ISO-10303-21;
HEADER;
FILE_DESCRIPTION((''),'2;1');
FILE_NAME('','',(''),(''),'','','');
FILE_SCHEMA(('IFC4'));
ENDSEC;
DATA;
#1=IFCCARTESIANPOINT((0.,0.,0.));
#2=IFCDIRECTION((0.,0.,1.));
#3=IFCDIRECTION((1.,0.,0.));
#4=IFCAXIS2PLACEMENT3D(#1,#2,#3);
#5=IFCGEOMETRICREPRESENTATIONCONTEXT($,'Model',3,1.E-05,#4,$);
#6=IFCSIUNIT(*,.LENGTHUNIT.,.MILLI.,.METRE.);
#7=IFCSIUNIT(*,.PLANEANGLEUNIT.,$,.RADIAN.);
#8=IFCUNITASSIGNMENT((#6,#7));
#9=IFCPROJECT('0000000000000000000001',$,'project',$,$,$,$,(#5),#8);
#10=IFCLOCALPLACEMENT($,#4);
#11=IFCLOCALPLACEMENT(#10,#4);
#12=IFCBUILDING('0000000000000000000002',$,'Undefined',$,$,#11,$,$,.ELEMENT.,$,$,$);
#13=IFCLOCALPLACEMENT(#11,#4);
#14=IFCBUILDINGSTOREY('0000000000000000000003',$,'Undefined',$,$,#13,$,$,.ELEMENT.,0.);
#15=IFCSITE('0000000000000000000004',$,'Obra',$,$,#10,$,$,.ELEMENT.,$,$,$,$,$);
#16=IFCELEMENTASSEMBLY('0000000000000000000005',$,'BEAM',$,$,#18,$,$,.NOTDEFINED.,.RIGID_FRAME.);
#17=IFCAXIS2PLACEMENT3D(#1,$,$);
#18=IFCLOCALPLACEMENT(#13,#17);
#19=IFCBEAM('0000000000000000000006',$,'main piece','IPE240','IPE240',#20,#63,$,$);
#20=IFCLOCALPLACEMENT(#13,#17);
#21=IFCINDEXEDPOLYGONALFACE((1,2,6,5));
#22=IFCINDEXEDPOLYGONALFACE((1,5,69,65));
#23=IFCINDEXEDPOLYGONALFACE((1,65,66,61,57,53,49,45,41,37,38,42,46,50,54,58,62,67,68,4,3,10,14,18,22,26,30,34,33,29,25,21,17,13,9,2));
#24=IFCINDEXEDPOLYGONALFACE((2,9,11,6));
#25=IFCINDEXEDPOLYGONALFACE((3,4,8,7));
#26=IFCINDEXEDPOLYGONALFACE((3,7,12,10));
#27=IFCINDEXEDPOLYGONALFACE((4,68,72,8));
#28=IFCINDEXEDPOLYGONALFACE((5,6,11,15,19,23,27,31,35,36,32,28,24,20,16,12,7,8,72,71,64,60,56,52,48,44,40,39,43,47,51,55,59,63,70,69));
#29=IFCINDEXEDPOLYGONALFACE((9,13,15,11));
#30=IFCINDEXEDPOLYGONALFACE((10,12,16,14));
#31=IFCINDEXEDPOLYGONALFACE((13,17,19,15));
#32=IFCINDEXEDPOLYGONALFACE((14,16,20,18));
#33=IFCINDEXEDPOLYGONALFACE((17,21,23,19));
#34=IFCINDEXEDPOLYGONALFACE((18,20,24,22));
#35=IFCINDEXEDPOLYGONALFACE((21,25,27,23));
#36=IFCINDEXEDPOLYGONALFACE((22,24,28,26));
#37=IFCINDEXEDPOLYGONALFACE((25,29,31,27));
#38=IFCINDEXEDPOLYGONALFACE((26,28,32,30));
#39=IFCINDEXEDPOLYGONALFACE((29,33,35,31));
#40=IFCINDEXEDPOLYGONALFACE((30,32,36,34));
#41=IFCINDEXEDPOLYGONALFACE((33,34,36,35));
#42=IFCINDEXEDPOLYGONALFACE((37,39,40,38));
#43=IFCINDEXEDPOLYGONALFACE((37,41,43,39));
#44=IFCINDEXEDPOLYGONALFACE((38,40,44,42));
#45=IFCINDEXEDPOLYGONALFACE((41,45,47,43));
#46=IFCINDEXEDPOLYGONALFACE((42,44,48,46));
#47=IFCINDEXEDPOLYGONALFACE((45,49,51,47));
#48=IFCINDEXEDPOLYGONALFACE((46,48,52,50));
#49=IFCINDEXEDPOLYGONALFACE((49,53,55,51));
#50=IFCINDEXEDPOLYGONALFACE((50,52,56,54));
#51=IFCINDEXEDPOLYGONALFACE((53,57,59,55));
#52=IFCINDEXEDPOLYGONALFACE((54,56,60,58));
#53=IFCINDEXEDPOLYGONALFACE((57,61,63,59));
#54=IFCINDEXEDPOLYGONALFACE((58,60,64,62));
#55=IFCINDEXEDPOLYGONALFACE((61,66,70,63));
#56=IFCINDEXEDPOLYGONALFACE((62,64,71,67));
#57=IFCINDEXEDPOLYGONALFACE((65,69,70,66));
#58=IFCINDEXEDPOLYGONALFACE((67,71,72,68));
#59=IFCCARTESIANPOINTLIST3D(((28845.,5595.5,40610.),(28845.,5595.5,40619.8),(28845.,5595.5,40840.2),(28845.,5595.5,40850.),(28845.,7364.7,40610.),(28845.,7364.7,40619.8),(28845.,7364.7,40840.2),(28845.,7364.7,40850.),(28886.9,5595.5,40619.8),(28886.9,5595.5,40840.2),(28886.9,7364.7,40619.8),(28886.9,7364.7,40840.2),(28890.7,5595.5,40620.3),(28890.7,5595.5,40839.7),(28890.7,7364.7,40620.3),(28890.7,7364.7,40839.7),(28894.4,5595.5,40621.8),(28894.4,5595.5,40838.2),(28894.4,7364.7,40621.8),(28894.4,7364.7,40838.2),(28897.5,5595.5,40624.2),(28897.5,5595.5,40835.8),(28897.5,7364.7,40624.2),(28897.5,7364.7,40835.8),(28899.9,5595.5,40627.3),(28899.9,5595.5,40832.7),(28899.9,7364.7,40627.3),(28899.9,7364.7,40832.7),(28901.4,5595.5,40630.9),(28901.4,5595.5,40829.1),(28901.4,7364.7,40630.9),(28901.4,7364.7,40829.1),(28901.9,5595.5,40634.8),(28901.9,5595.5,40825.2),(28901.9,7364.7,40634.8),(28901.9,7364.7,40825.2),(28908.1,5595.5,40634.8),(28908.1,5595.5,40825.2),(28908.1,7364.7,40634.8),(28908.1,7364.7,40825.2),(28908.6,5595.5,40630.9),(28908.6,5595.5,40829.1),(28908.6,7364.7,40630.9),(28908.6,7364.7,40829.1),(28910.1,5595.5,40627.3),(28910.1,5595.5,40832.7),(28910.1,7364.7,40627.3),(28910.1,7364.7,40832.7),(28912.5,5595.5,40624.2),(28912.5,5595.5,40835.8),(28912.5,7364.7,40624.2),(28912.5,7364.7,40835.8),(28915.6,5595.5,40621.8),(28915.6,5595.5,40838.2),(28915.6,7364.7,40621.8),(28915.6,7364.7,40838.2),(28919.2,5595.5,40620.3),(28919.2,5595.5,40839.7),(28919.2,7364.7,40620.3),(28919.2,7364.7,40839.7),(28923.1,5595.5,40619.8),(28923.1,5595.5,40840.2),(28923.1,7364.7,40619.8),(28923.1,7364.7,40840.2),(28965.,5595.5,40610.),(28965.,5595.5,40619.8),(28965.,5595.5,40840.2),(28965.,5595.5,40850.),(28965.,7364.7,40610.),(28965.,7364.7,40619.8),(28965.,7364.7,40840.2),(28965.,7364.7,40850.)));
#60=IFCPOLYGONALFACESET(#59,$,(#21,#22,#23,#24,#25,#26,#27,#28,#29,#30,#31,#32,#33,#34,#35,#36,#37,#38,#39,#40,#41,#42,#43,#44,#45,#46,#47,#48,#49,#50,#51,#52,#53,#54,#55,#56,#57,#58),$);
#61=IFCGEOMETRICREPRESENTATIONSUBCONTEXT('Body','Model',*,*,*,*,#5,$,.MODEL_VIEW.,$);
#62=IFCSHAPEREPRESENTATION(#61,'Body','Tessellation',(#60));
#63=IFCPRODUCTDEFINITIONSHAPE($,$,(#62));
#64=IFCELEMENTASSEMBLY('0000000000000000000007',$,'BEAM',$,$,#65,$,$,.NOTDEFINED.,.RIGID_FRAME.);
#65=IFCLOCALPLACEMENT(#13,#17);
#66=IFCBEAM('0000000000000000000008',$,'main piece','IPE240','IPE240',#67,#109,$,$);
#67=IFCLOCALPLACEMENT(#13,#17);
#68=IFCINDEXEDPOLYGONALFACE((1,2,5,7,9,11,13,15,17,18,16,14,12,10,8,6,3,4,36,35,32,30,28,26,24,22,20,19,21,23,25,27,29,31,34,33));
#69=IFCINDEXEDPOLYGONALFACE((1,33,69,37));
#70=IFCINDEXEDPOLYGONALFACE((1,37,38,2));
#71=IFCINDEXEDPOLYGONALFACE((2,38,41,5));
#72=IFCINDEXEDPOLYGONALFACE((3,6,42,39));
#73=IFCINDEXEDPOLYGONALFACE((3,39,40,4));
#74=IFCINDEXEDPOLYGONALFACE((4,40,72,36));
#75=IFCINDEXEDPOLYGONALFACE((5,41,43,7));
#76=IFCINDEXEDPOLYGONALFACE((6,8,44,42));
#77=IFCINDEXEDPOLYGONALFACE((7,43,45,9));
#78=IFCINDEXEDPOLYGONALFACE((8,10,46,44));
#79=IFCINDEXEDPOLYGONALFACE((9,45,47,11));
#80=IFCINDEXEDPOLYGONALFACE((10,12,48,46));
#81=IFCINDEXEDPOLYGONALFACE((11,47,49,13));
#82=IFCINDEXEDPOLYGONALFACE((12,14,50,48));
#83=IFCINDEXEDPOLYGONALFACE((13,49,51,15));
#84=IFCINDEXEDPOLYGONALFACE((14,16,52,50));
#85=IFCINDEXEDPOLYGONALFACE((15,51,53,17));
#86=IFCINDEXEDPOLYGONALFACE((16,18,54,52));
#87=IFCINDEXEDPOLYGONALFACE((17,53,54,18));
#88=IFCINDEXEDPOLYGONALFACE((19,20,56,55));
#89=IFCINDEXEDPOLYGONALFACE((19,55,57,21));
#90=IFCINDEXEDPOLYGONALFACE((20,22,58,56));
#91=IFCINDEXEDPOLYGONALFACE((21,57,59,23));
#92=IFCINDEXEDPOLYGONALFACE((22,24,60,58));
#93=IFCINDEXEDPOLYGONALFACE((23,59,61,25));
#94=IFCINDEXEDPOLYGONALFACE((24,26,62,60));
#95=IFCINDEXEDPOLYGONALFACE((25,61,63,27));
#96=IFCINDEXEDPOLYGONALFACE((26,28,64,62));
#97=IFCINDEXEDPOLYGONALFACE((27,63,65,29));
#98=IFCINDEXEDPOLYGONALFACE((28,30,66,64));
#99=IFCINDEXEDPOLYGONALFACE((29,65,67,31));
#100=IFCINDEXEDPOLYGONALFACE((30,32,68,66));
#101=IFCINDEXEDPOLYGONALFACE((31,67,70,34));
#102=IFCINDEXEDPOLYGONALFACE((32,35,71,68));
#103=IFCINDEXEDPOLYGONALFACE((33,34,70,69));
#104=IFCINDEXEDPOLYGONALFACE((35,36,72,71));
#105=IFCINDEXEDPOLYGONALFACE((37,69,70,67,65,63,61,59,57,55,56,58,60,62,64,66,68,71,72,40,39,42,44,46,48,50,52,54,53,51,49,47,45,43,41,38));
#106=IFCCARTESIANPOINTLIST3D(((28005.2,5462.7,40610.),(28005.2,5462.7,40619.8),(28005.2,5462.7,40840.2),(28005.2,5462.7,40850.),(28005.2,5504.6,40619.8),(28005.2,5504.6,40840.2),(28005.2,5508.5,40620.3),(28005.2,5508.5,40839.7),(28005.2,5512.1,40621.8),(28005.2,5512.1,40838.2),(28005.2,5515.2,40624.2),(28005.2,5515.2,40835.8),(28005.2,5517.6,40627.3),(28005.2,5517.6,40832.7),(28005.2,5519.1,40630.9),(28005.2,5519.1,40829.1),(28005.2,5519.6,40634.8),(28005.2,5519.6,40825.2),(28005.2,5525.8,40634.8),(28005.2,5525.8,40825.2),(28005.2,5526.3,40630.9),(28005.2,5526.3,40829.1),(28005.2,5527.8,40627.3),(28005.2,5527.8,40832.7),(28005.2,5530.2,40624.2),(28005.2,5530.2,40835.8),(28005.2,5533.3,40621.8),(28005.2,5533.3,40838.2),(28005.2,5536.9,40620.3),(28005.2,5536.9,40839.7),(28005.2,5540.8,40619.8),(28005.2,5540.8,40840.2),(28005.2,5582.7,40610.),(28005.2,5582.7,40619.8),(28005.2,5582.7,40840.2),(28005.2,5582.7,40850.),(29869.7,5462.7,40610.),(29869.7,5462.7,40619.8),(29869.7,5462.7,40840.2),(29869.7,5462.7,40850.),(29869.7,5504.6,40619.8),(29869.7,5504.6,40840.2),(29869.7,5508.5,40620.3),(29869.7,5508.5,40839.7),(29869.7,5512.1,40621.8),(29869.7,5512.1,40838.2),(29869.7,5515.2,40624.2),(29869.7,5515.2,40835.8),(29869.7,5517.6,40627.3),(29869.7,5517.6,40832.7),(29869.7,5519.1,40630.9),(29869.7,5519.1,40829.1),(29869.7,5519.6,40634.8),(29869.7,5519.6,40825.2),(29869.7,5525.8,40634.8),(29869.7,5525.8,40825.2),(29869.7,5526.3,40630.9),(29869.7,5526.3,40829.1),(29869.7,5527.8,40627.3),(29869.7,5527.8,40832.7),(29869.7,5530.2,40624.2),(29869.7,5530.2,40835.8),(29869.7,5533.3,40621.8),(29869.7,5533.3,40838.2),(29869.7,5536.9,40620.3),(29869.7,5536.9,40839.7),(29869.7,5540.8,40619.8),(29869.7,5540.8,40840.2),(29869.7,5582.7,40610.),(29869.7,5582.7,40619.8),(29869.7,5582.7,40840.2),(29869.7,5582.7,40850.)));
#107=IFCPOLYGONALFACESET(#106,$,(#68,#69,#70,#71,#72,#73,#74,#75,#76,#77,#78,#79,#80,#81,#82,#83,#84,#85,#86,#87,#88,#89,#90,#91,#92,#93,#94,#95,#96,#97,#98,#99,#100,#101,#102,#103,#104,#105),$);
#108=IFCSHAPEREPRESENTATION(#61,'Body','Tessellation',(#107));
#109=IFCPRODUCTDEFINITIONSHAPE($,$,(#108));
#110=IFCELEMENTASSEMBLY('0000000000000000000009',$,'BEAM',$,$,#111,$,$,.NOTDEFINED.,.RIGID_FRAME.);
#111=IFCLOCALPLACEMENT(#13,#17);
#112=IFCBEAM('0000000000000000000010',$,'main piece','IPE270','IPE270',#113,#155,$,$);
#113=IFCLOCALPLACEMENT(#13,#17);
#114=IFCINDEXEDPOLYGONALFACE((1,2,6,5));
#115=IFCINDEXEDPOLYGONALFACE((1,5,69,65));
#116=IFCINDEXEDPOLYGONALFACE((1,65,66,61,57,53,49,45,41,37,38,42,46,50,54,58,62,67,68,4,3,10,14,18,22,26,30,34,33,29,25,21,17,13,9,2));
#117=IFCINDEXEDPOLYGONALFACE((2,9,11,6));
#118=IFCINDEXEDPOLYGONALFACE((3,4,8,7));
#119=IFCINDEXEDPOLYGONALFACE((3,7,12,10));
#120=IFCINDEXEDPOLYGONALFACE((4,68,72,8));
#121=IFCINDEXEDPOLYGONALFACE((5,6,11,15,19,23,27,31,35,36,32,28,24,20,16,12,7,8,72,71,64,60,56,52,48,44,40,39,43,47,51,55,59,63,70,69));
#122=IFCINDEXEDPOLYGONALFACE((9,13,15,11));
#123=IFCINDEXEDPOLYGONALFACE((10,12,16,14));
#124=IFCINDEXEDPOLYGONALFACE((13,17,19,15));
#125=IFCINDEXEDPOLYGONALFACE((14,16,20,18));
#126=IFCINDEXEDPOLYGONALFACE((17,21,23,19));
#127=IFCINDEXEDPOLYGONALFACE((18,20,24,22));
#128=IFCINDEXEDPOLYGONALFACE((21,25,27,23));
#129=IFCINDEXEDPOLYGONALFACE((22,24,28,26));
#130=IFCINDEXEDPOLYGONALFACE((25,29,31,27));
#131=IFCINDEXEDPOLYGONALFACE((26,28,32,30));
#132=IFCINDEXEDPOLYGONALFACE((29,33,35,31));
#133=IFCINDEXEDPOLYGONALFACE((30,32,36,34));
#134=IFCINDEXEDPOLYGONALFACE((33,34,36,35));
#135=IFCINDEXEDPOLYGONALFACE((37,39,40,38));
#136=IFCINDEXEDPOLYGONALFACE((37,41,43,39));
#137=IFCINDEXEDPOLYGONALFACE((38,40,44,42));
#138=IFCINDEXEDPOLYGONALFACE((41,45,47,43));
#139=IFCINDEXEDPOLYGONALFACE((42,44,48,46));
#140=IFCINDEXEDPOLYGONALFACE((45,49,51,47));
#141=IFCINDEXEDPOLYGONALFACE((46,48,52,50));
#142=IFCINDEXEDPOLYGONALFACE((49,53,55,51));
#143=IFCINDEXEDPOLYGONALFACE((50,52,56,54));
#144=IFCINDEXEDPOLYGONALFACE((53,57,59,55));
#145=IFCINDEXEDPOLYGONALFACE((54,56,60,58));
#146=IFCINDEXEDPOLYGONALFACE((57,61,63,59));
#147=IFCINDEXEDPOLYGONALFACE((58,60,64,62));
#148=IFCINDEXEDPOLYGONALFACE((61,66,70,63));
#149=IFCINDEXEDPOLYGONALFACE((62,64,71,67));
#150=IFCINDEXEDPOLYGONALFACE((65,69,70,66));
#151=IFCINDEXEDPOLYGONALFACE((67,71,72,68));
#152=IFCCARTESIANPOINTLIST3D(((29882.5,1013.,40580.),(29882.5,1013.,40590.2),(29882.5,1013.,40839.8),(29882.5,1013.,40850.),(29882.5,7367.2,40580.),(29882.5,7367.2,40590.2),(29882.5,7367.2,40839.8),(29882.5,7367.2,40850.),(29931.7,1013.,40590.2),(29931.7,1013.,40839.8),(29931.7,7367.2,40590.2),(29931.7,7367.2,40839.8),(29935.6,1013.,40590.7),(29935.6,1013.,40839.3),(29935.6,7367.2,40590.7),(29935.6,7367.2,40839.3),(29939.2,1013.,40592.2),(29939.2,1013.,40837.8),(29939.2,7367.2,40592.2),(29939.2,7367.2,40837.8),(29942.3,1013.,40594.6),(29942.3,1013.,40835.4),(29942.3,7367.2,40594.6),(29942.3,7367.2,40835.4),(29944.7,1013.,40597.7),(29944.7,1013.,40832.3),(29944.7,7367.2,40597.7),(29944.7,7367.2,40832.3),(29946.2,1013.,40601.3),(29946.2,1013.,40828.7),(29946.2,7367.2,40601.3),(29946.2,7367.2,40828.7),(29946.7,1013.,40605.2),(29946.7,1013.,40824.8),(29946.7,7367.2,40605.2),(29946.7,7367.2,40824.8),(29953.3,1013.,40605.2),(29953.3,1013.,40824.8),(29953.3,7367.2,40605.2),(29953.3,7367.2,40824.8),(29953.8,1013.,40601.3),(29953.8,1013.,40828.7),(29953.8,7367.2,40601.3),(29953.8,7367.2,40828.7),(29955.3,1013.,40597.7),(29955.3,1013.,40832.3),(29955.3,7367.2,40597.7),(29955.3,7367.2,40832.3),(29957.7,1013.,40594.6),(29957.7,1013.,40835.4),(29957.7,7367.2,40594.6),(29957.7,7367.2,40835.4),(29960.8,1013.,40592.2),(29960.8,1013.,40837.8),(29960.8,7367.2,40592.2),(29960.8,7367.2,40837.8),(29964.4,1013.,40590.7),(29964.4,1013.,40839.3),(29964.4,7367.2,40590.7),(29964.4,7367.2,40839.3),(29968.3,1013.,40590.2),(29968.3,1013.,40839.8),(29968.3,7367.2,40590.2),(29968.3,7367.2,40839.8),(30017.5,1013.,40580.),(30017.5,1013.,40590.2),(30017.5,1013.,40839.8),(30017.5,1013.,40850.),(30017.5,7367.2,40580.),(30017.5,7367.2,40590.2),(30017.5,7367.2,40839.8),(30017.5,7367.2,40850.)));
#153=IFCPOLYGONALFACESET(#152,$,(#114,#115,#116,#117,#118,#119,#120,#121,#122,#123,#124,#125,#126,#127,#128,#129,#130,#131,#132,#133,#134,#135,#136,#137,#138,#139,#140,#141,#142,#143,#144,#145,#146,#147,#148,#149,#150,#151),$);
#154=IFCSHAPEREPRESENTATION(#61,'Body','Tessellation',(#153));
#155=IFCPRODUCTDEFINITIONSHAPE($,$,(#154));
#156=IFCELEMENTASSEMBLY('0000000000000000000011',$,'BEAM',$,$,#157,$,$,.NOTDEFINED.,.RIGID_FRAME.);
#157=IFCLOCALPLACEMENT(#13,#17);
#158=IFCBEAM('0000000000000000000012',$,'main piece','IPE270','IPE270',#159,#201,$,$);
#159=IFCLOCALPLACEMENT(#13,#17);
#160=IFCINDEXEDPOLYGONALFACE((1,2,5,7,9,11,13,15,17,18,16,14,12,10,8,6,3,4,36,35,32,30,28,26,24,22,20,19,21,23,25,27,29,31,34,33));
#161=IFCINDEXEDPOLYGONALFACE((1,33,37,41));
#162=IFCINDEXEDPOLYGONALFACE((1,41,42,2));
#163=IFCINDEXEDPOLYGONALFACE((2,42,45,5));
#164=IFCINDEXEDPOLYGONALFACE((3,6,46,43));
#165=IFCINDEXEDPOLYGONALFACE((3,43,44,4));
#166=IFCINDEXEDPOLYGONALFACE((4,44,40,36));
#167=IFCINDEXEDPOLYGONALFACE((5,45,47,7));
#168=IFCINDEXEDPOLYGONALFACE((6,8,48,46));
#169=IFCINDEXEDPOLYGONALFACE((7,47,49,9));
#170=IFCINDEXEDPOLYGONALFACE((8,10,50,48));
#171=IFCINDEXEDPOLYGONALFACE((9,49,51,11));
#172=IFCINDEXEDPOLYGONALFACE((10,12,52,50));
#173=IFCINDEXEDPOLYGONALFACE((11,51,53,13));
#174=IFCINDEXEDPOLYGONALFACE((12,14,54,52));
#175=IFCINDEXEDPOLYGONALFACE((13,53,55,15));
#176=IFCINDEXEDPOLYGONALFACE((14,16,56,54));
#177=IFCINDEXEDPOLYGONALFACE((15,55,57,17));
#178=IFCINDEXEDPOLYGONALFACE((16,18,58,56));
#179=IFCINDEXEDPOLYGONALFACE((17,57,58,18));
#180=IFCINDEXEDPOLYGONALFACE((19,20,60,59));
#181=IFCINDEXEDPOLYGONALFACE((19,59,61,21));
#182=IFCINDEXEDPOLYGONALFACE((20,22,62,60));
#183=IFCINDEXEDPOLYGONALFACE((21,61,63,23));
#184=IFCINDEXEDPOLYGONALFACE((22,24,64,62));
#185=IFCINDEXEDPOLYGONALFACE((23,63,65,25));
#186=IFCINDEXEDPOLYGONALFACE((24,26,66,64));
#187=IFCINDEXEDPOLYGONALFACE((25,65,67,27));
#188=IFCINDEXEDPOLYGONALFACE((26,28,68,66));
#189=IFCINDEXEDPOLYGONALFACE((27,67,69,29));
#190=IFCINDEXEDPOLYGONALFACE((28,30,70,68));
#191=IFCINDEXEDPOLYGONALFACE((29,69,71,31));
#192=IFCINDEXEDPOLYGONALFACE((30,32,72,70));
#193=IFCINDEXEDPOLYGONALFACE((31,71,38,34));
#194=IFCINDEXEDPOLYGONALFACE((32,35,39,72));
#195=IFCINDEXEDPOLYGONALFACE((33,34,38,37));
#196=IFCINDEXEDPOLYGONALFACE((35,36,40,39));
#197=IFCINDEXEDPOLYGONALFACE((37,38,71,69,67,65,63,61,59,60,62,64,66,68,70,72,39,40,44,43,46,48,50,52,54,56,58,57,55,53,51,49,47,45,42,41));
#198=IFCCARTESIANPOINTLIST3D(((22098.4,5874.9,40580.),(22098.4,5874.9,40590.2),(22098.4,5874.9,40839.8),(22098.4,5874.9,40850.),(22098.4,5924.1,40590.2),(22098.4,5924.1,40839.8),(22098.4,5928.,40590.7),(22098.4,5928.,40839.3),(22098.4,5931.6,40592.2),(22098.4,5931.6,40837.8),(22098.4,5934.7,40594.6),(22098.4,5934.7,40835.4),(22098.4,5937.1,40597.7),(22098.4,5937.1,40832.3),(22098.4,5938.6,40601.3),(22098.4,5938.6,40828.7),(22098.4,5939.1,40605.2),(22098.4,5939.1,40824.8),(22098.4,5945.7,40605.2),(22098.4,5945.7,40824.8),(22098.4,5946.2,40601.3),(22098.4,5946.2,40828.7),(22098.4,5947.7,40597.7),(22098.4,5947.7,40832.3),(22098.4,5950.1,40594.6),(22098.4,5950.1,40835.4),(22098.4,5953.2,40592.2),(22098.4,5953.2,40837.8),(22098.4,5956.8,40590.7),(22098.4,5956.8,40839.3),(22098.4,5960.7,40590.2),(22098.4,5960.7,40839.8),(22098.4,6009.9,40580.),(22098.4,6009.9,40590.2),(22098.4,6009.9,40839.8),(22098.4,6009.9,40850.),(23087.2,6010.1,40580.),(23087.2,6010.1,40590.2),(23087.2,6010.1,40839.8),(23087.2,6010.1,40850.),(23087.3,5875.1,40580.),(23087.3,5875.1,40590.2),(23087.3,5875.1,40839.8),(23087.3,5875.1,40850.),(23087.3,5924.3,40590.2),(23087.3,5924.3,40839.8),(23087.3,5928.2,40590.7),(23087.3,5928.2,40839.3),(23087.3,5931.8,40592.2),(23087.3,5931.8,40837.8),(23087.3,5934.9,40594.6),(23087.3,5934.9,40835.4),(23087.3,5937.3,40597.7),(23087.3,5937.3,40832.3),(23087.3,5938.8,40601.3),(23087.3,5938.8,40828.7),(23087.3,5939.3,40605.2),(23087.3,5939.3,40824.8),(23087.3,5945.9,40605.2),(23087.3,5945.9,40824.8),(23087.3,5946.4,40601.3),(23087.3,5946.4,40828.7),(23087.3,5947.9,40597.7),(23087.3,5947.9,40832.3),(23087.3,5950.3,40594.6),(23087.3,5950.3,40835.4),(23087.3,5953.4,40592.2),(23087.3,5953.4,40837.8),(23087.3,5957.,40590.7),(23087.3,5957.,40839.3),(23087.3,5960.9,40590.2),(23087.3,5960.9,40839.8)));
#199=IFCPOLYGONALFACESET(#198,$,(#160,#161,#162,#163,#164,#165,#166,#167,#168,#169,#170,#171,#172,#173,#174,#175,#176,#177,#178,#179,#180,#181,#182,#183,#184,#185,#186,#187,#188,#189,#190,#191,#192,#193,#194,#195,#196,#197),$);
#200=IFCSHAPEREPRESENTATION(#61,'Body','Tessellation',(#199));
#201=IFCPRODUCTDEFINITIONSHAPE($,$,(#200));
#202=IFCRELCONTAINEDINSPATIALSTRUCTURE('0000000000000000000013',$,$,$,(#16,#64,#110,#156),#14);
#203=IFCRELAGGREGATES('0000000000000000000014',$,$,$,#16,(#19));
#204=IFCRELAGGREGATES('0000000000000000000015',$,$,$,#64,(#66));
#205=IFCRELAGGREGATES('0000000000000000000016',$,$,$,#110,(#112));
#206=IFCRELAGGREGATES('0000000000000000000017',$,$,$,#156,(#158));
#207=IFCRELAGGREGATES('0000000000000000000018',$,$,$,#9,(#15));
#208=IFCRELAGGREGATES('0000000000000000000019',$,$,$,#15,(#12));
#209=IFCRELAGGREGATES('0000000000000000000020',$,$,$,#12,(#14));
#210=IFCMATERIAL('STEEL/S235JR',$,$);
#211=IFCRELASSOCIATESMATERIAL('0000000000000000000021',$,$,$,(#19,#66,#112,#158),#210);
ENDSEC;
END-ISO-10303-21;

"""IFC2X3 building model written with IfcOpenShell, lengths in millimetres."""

from ifc_helpers import new_model, si_unit, frame, origin_with_axes, origin_2d_with_axis, place, context, subcontext, project, spatial, i_section, extrude, material, element, aggregate, save


model = new_model("IFC2X3")

# Units and contexts
model_context = context("Model", 3, precision=1e-05, world=origin_with_axes())
body_context = subcontext(model_context, "Body", "Model", "MODEL_VIEW")
ifc_project = project(units=[si_unit("LENGTHUNIT", "METRE", prefix="MILLI"), si_unit("PLANEANGLEUNIT", "RADIAN")], contexts=[model_context])

# Site, building, storey
site_placement = place(None, origin_with_axes())
site = spatial("IfcSite", under=ifc_project, at=site_placement, Name="Obra", CompositionType="ELEMENT")
building_placement = place(site_placement, origin_with_axes())
building = spatial("IfcBuilding", under=site, at=building_placement, Name="Undefined", CompositionType="ELEMENT")
storey_placement = place(building_placement, origin_with_axes())
storey = spatial("IfcBuildingStorey", under=building, at=storey_placement, Name="Undefined", CompositionType="ELEMENT", Elevation=0.0)

# Element assemblies, beams
ifc_material_1 = material(Name="STEEL/S235JR")
assembly_1_placement = place(storey_placement, origin_with_axes())
assembly_1 = element("IfcElementAssembly", 1, at=assembly_1_placement, inside=storey, Name="BEAM", AssemblyPlace="NOTDEFINED", PredefinedType="RIGID_FRAME")
beam_1_placement = place(assembly_1_placement, frame((28905.0, 5595.5, 40730.0), z_axis=(0.0, 0.0, 1.0), x_axis=(-0.000001, 1.0, 0.0)))
beam_1 = element("IfcBeam", 2, at=beam_1_placement, material=ifc_material_1, Name="main piece", Description="IPE240", ObjectType="IPE240", context=body_context, shape_type="SweptSolid", body=[
    extrude(i_section(OverallWidth=120.0, OverallDepth=240.0, WebThickness=6.2, FlangeThickness=9.8, FilletRadius=15.0, at=origin_2d_with_axis()), frame((1769.2, 0.0, 0.0), z_axis=(-1.0, 0.0, 0.0), x_axis=(0.0, -1.0, 0.0)), (0.0, 0.0, 1.0), 1769.2),
])
aggregate(assembly_1, [beam_1])
assembly_2_placement = place(storey_placement, origin_with_axes())
assembly_2 = element("IfcElementAssembly", 3, at=assembly_2_placement, inside=storey, Name="BEAM", AssemblyPlace="NOTDEFINED", PredefinedType="RIGID_FRAME")
beam_2_placement = place(assembly_2_placement, frame((28005.2, 5522.7, 40730.0), z_axis=(0.0, 0.0, 1.0), x_axis=(1.0, 0.000002, 0.0)))
beam_2 = element("IfcBeam", 4, at=beam_2_placement, material=ifc_material_1, Name="main piece", Description="IPE240", ObjectType="IPE240", context=body_context, shape_type="SweptSolid", body=[
    extrude(i_section(OverallWidth=120.0, OverallDepth=240.0, WebThickness=6.2, FlangeThickness=9.8, FilletRadius=15.0, at=origin_2d_with_axis()), frame((1864.5, 0.0, 0.0), z_axis=(-1.0, 0.0, 0.0), x_axis=(0.0, -1.0, 0.0)), (0.0, 0.0, 1.0), 1864.5),
])
aggregate(assembly_2, [beam_2])
assembly_3_placement = place(storey_placement, origin_with_axes())
assembly_3 = element("IfcElementAssembly", 5, at=assembly_3_placement, inside=storey, Name="BEAM", AssemblyPlace="NOTDEFINED", PredefinedType="RIGID_FRAME")
beam_3_placement = place(assembly_3_placement, frame((29950.0, 1013.0, 40715.0), z_axis=(0.0, 0.0, 1.0), x_axis=(-0.000002, 1.0, 0.0)))
beam_3 = element("IfcBeam", 6, at=beam_3_placement, material=ifc_material_1, Name="main piece", Description="IPE270", ObjectType="IPE270", context=body_context, shape_type="SweptSolid", body=[
    extrude(i_section(OverallWidth=135.0, OverallDepth=270.0, WebThickness=6.6, FlangeThickness=10.2, FilletRadius=15.0, at=origin_2d_with_axis()), frame((6354.2, 0.0, 0.0), z_axis=(-1.0, 0.0, 0.0), x_axis=(0.0, -1.0, 0.0)), (0.0, 0.0, 1.0), 6354.2),
])
aggregate(assembly_3, [beam_3])
assembly_4_placement = place(storey_placement, origin_with_axes())
assembly_4 = element("IfcElementAssembly", 7, at=assembly_4_placement, inside=storey, Name="BEAM", AssemblyPlace="NOTDEFINED", PredefinedType="RIGID_FRAME")
beam_4_placement = place(assembly_4_placement, frame((23087.3, 5942.6, 40715.0), z_axis=(0.0, 0.0, 1.0), x_axis=(-1.0, -0.00023, 0.0)))
beam_4 = element("IfcBeam", 8, at=beam_4_placement, material=ifc_material_1, Name="main piece", Description="IPE270", ObjectType="IPE270", context=body_context, shape_type="SweptSolid", body=[
    extrude(i_section(OverallWidth=135.0, OverallDepth=270.0, WebThickness=6.6, FlangeThickness=10.2, FilletRadius=15.0, at=origin_2d_with_axis()), frame((988.8, 0.0, 0.0), z_axis=(-1.0, 0.0, 0.0), x_axis=(0.0, -1.0, 0.0)), (0.0, 0.0, 1.0), 988.9),
])
aggregate(assembly_4, [beam_4])

save(model, "model.ifc")
